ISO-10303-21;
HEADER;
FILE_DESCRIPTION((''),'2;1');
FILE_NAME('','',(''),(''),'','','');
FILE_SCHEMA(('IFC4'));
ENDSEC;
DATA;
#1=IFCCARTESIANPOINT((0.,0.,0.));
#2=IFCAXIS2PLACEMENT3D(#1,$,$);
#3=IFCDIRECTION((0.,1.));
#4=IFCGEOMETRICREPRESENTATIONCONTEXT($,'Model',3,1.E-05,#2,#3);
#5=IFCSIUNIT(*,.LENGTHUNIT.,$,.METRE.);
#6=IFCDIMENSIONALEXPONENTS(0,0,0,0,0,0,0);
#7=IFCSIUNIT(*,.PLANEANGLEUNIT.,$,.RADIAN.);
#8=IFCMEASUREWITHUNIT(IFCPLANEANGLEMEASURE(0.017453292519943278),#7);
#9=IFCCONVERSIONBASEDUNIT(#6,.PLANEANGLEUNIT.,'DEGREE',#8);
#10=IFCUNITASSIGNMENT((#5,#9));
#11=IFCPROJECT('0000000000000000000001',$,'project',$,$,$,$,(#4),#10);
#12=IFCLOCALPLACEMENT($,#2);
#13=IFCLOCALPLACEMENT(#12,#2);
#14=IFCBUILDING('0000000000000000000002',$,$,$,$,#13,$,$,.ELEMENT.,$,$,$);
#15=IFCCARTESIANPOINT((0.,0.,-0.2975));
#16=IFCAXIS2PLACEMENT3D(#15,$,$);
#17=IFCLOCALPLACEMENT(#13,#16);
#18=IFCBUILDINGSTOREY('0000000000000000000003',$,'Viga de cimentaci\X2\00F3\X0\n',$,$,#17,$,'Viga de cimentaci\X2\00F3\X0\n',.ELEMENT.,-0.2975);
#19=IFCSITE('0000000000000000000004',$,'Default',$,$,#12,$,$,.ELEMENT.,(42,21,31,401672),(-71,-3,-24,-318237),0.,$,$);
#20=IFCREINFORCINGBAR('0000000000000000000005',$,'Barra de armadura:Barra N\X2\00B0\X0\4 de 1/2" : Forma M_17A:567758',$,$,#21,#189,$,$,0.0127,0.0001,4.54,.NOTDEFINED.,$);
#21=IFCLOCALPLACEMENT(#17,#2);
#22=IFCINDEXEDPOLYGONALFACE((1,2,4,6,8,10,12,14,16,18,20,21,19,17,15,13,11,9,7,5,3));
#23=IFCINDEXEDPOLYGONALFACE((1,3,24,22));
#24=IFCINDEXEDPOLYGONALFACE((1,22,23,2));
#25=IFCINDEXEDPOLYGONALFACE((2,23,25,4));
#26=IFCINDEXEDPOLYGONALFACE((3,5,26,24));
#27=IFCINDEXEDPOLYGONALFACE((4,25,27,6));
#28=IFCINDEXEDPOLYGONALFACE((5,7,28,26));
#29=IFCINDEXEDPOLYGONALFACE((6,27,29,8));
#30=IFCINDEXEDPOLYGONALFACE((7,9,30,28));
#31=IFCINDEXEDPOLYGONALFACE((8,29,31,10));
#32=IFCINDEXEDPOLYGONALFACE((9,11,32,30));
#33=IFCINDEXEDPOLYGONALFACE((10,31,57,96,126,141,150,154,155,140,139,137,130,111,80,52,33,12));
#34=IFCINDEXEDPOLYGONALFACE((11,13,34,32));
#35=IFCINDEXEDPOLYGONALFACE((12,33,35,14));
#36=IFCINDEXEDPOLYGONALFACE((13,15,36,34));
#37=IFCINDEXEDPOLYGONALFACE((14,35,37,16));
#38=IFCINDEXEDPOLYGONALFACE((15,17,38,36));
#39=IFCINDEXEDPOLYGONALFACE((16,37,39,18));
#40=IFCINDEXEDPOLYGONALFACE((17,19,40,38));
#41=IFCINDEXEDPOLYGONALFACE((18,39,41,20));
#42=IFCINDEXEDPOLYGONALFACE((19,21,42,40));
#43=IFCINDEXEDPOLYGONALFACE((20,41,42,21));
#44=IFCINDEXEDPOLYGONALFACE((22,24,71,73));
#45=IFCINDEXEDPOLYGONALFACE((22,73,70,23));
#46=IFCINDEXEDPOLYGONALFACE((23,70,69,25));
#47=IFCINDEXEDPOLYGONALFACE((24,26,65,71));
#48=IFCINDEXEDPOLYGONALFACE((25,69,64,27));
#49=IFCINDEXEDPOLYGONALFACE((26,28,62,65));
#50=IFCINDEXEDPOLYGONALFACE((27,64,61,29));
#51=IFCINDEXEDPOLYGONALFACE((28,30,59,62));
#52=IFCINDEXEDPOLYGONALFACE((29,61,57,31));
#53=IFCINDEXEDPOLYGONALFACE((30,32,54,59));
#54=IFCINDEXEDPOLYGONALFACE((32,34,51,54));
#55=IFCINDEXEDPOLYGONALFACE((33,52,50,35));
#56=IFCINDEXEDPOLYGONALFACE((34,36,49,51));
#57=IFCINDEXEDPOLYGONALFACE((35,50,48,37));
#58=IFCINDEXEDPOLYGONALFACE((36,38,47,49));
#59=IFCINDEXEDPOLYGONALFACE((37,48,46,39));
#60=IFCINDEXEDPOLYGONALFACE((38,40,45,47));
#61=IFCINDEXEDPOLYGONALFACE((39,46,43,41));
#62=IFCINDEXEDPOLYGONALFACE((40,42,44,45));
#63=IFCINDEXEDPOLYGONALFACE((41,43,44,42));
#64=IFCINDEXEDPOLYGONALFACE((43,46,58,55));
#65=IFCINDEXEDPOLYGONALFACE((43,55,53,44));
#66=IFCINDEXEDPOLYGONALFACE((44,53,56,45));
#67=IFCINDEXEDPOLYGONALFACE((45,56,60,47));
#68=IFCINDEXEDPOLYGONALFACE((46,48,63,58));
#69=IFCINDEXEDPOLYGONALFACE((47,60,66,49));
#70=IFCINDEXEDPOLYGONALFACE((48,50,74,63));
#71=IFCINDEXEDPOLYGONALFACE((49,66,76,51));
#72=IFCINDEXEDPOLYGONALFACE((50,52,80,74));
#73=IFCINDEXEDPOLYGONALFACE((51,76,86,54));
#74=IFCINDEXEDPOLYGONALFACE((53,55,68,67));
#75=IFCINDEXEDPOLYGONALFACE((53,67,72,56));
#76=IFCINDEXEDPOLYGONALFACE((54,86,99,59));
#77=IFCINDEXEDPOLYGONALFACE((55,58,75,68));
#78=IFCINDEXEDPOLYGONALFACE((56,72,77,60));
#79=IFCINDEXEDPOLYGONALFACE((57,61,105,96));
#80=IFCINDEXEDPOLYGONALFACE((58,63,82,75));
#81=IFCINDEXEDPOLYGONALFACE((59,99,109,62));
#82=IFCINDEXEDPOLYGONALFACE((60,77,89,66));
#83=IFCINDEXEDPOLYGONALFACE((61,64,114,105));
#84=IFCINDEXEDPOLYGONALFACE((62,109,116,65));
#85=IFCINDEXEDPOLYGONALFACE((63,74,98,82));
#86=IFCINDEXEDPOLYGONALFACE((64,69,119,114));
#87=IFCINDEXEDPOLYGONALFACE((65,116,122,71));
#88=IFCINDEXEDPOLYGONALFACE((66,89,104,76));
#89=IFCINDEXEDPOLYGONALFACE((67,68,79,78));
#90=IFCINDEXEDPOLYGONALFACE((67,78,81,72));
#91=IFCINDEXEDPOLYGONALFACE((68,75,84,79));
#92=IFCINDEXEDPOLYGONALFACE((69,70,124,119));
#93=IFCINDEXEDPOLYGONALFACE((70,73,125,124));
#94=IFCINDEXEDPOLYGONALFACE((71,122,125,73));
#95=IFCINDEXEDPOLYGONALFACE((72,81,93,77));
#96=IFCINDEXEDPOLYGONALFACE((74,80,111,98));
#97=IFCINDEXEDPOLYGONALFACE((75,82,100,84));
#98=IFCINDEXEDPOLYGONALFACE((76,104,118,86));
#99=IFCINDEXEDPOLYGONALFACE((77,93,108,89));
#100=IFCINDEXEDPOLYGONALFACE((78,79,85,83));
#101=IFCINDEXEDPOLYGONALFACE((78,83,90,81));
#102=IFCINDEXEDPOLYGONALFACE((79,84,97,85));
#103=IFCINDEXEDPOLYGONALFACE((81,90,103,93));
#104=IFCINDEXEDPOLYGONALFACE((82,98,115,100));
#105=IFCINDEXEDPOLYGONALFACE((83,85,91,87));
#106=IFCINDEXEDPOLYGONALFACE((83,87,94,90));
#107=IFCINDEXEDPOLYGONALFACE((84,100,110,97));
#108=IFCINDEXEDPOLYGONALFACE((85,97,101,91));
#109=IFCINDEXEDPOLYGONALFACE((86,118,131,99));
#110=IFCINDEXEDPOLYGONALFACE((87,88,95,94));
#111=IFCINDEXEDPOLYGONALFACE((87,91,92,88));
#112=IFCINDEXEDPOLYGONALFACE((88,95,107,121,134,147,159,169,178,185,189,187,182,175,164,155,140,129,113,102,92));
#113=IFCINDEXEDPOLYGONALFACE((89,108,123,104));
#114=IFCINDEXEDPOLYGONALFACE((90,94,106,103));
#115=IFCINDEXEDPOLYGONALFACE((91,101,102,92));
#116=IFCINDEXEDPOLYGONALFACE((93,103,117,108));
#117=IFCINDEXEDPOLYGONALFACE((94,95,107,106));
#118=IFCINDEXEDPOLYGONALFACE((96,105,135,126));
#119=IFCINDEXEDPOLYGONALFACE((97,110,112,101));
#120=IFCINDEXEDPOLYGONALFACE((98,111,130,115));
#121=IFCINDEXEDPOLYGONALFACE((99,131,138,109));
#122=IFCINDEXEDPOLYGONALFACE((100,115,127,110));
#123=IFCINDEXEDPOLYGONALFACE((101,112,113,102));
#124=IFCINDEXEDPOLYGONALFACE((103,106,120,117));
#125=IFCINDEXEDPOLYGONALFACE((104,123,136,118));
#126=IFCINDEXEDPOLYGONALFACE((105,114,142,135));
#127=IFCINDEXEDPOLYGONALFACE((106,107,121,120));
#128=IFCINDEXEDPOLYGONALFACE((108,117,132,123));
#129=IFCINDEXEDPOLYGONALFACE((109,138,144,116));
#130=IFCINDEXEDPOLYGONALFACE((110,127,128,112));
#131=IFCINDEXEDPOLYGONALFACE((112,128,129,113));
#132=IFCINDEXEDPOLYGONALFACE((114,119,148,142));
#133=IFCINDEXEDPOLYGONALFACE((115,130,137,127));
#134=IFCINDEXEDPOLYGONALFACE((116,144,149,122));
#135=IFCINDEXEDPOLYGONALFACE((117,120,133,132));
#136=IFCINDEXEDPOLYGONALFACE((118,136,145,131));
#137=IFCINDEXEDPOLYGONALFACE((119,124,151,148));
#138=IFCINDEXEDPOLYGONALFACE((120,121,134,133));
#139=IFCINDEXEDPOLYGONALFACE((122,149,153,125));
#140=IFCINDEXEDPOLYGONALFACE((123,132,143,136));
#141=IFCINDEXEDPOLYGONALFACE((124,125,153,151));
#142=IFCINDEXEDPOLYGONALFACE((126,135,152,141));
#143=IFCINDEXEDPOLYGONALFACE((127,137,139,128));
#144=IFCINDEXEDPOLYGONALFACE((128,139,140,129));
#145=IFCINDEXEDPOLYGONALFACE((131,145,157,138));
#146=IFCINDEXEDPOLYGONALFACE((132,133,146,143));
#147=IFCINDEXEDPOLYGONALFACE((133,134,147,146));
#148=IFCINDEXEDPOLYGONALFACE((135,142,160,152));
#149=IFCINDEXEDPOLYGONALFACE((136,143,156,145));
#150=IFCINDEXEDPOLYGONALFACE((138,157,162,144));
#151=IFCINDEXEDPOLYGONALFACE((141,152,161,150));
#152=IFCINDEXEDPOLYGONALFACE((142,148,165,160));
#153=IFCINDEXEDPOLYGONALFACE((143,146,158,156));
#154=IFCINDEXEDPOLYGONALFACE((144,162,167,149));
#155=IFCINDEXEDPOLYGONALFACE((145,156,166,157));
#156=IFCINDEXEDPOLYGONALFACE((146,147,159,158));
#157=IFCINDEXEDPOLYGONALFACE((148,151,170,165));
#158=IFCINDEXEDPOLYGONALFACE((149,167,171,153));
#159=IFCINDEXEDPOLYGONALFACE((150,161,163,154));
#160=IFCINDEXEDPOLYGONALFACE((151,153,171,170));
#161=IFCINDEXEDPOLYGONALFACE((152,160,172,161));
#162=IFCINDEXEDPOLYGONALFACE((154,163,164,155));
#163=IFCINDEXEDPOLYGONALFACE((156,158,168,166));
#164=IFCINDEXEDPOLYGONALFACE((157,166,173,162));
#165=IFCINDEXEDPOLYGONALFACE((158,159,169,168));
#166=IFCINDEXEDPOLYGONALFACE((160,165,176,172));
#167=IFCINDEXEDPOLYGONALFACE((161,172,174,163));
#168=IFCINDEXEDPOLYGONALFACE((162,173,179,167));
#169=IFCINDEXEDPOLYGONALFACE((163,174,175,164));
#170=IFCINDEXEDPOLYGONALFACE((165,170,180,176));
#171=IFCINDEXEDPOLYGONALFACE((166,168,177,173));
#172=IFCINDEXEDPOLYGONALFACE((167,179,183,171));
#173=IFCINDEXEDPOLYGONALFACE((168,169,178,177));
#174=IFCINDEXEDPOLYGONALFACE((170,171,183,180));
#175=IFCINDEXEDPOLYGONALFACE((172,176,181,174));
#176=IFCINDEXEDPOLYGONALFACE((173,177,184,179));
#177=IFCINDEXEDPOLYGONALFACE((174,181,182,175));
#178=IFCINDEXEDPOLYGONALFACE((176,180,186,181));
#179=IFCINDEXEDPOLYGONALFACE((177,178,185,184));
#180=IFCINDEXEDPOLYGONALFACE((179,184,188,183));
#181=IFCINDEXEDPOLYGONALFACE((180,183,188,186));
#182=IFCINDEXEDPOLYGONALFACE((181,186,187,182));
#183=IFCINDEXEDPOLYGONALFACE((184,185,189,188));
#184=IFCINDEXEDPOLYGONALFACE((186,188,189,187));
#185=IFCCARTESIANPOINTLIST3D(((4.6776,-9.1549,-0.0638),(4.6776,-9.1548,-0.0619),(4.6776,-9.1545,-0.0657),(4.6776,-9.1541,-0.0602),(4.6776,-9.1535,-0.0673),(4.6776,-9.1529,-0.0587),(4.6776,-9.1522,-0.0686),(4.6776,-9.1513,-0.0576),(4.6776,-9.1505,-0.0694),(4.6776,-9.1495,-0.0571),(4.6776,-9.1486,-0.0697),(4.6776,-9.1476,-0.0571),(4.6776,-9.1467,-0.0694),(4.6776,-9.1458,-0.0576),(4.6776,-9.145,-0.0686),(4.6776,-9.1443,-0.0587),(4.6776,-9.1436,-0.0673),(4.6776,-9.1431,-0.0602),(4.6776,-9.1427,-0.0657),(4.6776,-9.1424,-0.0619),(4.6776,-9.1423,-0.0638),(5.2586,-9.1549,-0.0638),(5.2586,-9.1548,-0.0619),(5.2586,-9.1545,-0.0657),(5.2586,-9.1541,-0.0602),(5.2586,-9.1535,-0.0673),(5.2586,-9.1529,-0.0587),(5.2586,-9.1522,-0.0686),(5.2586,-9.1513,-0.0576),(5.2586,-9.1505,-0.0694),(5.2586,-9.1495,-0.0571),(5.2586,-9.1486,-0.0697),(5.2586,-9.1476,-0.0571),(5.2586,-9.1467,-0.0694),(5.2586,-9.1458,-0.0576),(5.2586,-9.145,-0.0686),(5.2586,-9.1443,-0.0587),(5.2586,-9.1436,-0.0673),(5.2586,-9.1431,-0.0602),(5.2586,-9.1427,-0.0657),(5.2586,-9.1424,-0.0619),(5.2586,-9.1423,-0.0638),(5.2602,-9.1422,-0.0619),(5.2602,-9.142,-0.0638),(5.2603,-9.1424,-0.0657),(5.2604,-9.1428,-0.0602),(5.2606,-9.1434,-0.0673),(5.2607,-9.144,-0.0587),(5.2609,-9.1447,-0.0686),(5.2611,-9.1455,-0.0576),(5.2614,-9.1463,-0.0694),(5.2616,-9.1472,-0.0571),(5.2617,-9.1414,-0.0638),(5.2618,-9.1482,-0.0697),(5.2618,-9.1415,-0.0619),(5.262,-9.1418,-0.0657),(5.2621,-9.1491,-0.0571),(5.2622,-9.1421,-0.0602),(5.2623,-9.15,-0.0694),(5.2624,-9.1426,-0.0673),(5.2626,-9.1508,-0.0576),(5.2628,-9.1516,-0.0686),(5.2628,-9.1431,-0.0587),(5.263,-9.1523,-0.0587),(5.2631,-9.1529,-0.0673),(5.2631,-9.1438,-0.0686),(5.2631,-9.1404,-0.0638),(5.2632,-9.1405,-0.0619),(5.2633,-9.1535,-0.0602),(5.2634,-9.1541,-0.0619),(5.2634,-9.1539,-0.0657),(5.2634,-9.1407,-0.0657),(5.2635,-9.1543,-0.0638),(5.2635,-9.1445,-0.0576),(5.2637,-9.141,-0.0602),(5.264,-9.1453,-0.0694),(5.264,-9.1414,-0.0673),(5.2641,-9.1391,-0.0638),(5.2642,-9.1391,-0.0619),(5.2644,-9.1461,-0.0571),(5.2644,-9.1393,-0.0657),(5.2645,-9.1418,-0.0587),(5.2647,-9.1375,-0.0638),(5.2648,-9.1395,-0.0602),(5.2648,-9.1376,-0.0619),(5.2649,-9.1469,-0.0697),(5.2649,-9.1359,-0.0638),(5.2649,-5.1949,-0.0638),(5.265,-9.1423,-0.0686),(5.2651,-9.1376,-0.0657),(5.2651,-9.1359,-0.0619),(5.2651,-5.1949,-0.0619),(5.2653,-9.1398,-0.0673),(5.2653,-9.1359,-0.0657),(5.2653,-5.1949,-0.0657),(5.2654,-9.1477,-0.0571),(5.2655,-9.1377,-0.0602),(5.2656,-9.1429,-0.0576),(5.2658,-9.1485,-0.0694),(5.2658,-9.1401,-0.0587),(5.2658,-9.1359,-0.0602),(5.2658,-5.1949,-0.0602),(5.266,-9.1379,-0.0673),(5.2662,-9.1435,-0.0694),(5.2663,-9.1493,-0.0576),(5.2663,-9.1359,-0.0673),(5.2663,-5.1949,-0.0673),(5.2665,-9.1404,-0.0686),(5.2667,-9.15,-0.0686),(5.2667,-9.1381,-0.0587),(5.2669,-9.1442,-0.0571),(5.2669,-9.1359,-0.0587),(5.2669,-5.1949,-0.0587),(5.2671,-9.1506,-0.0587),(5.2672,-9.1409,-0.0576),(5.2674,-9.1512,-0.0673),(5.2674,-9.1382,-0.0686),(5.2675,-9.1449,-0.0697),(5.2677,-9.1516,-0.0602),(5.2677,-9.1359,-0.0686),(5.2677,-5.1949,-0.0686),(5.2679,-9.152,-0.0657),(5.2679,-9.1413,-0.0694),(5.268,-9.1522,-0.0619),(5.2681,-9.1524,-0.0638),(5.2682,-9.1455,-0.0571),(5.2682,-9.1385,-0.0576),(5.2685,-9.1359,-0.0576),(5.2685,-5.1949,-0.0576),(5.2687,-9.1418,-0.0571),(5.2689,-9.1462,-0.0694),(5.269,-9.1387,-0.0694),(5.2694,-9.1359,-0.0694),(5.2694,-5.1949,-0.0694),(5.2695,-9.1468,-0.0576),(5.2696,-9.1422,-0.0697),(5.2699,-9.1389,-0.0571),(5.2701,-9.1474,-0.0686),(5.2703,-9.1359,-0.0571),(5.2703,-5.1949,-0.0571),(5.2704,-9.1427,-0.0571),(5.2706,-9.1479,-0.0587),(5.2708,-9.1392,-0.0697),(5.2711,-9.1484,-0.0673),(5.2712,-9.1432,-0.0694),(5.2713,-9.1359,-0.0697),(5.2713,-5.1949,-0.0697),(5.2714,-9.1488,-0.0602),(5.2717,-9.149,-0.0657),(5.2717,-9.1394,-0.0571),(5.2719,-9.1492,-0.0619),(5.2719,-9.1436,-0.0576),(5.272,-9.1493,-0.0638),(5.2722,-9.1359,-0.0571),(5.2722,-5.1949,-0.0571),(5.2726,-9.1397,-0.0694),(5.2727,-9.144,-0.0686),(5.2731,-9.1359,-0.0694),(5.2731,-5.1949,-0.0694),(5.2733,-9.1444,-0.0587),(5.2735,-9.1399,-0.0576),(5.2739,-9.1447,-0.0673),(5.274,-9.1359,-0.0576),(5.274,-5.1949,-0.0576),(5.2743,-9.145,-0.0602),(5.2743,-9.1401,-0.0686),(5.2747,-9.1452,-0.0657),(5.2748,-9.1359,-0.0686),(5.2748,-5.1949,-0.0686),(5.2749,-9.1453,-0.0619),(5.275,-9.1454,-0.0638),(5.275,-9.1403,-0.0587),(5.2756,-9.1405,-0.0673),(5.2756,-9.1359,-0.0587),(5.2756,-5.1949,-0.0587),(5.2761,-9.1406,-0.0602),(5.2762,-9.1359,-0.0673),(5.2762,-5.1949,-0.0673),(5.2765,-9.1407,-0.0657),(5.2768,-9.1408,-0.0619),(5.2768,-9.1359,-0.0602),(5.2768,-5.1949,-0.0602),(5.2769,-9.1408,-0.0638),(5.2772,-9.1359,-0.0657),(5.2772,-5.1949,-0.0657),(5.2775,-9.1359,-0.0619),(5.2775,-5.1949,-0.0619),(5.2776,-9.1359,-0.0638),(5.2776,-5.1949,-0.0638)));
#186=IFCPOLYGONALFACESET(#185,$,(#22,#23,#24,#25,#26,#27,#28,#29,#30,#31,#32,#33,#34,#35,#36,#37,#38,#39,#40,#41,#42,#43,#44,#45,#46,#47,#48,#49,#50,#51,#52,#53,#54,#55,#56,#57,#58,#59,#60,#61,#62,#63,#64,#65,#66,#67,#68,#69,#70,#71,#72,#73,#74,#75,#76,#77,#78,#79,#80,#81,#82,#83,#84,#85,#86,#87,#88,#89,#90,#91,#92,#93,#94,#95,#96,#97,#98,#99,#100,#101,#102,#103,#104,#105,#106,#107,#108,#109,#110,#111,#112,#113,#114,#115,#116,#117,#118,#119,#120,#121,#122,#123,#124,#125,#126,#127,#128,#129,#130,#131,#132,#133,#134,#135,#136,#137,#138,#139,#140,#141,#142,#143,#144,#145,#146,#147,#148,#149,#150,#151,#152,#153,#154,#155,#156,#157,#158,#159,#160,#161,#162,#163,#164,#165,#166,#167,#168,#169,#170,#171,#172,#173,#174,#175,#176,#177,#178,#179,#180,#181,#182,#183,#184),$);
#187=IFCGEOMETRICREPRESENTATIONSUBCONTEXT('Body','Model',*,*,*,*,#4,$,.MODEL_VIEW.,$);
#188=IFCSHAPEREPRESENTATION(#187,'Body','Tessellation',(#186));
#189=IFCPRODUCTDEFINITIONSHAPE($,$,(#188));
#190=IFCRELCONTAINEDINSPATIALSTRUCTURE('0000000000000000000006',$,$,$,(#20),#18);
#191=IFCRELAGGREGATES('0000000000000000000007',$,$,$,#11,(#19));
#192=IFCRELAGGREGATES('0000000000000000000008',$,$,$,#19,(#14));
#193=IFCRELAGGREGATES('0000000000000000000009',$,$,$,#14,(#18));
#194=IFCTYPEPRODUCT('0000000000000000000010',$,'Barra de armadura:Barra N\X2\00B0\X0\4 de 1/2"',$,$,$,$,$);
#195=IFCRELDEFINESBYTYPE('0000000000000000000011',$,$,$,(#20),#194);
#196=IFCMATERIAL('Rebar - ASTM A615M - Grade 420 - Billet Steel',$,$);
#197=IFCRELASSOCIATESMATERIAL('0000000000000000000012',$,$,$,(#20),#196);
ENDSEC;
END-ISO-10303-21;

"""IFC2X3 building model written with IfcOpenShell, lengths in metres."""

from ifc_helpers import new_model, entity, si_unit, converted_unit, direction, frame, origin, place, context, subcontext, project, spatial, material, type_object, element, save


model = new_model("IFC2X3")

# Units and contexts
model_context = context("Model", 3, precision=1e-05, world=origin(), true_north=direction((0.0, 1.0)))
body_context = subcontext(model_context, "Body", "Model", "MODEL_VIEW")
ifc_project = project(units=[si_unit("LENGTHUNIT", "METRE"), converted_unit("PLANEANGLEUNIT", "DEGREE", entity("IfcPlaneAngleMeasure", 0.017453292519943278), si_unit("PLANEANGLEUNIT", "RADIAN"), dimensions=[0, 0, 0, 0, 0, 0, 0])], contexts=[model_context])

# Site, building, storey
site_placement = place(None, origin())
site = spatial("IfcSite", under=ifc_project, at=site_placement, Name="Default", CompositionType="ELEMENT", RefLatitude=(42, 21, 31, 401672), RefLongitude=(-71, -3, -24, -318237), RefElevation=0.0)
building_placement = place(site_placement, origin())
building = spatial("IfcBuilding", under=site, at=building_placement, CompositionType="ELEMENT")
storey_placement = place(building_placement, frame((0.0, 0.0, -0.2975)))
storey = spatial("IfcBuildingStorey", under=building, at=storey_placement, Name="Viga de cimentación", LongName="Viga de cimentación", CompositionType="ELEMENT", Elevation=-0.2975)

# Reinforcing bar
ifc_material = material(Name="Rebar - ASTM A615M - Grade 420 - Billet Steel")
type_product_1 = type_object("IfcTypeProduct", Name="Barra de armadura:Barra N°4 de 1/2\"")
reinforcing_bar_1_placement = place(storey_placement, origin())
element("IfcReinforcingBar", 1, at=reinforcing_bar_1_placement, inside=storey, type_object=type_product_1, material=ifc_material, Name="Barra de armadura:Barra N°4 de 1/2\" : Forma M_17A:567758", BarLength=4.54, BarRole="NOTDEFINED", CrossSectionArea=0.0001, NominalDiameter=0.0127, context=body_context, shape_type="AdvancedSweptSolid", body=[
    entity("IfcSweptDiskSolid", entity("IfcCompositeCurve", [entity("IfcCompositeCurveSegment", "CONTINUOUS", True, entity("IfcPolyline", [entity("IfcCartesianPoint", [5.2713, -5.1949, -0.0634]), entity("IfcCartesianPoint", [5.2713, -9.1359, -0.0634])])), entity("IfcCompositeCurveSegment", "CONTINUOUS", True, entity("IfcTrimmedCurve", entity("IfcCircle", entity("IfcAxis2Placement3D", entity("IfcCartesianPoint", [5.2586, -9.1359, -0.0634]), entity("IfcDirection", [0.0, 0.0, -1.0]), entity("IfcDirection", [0.0, -1.0, 0.0])), 0.0127), [entity("IfcParameterValue", 270.0)], [entity("IfcParameterValue", 360.0)], True, "PARAMETER")), entity("IfcCompositeCurveSegment", "CONTINUOUS", True, entity("IfcPolyline", [entity("IfcCartesianPoint", [5.2586, -9.1486, -0.0634]), entity("IfcCartesianPoint", [4.6776, -9.1486, -0.0634])]))], False), 0.0063, None, 0.0, 92.0),
])

save(model, "model.ifc")
